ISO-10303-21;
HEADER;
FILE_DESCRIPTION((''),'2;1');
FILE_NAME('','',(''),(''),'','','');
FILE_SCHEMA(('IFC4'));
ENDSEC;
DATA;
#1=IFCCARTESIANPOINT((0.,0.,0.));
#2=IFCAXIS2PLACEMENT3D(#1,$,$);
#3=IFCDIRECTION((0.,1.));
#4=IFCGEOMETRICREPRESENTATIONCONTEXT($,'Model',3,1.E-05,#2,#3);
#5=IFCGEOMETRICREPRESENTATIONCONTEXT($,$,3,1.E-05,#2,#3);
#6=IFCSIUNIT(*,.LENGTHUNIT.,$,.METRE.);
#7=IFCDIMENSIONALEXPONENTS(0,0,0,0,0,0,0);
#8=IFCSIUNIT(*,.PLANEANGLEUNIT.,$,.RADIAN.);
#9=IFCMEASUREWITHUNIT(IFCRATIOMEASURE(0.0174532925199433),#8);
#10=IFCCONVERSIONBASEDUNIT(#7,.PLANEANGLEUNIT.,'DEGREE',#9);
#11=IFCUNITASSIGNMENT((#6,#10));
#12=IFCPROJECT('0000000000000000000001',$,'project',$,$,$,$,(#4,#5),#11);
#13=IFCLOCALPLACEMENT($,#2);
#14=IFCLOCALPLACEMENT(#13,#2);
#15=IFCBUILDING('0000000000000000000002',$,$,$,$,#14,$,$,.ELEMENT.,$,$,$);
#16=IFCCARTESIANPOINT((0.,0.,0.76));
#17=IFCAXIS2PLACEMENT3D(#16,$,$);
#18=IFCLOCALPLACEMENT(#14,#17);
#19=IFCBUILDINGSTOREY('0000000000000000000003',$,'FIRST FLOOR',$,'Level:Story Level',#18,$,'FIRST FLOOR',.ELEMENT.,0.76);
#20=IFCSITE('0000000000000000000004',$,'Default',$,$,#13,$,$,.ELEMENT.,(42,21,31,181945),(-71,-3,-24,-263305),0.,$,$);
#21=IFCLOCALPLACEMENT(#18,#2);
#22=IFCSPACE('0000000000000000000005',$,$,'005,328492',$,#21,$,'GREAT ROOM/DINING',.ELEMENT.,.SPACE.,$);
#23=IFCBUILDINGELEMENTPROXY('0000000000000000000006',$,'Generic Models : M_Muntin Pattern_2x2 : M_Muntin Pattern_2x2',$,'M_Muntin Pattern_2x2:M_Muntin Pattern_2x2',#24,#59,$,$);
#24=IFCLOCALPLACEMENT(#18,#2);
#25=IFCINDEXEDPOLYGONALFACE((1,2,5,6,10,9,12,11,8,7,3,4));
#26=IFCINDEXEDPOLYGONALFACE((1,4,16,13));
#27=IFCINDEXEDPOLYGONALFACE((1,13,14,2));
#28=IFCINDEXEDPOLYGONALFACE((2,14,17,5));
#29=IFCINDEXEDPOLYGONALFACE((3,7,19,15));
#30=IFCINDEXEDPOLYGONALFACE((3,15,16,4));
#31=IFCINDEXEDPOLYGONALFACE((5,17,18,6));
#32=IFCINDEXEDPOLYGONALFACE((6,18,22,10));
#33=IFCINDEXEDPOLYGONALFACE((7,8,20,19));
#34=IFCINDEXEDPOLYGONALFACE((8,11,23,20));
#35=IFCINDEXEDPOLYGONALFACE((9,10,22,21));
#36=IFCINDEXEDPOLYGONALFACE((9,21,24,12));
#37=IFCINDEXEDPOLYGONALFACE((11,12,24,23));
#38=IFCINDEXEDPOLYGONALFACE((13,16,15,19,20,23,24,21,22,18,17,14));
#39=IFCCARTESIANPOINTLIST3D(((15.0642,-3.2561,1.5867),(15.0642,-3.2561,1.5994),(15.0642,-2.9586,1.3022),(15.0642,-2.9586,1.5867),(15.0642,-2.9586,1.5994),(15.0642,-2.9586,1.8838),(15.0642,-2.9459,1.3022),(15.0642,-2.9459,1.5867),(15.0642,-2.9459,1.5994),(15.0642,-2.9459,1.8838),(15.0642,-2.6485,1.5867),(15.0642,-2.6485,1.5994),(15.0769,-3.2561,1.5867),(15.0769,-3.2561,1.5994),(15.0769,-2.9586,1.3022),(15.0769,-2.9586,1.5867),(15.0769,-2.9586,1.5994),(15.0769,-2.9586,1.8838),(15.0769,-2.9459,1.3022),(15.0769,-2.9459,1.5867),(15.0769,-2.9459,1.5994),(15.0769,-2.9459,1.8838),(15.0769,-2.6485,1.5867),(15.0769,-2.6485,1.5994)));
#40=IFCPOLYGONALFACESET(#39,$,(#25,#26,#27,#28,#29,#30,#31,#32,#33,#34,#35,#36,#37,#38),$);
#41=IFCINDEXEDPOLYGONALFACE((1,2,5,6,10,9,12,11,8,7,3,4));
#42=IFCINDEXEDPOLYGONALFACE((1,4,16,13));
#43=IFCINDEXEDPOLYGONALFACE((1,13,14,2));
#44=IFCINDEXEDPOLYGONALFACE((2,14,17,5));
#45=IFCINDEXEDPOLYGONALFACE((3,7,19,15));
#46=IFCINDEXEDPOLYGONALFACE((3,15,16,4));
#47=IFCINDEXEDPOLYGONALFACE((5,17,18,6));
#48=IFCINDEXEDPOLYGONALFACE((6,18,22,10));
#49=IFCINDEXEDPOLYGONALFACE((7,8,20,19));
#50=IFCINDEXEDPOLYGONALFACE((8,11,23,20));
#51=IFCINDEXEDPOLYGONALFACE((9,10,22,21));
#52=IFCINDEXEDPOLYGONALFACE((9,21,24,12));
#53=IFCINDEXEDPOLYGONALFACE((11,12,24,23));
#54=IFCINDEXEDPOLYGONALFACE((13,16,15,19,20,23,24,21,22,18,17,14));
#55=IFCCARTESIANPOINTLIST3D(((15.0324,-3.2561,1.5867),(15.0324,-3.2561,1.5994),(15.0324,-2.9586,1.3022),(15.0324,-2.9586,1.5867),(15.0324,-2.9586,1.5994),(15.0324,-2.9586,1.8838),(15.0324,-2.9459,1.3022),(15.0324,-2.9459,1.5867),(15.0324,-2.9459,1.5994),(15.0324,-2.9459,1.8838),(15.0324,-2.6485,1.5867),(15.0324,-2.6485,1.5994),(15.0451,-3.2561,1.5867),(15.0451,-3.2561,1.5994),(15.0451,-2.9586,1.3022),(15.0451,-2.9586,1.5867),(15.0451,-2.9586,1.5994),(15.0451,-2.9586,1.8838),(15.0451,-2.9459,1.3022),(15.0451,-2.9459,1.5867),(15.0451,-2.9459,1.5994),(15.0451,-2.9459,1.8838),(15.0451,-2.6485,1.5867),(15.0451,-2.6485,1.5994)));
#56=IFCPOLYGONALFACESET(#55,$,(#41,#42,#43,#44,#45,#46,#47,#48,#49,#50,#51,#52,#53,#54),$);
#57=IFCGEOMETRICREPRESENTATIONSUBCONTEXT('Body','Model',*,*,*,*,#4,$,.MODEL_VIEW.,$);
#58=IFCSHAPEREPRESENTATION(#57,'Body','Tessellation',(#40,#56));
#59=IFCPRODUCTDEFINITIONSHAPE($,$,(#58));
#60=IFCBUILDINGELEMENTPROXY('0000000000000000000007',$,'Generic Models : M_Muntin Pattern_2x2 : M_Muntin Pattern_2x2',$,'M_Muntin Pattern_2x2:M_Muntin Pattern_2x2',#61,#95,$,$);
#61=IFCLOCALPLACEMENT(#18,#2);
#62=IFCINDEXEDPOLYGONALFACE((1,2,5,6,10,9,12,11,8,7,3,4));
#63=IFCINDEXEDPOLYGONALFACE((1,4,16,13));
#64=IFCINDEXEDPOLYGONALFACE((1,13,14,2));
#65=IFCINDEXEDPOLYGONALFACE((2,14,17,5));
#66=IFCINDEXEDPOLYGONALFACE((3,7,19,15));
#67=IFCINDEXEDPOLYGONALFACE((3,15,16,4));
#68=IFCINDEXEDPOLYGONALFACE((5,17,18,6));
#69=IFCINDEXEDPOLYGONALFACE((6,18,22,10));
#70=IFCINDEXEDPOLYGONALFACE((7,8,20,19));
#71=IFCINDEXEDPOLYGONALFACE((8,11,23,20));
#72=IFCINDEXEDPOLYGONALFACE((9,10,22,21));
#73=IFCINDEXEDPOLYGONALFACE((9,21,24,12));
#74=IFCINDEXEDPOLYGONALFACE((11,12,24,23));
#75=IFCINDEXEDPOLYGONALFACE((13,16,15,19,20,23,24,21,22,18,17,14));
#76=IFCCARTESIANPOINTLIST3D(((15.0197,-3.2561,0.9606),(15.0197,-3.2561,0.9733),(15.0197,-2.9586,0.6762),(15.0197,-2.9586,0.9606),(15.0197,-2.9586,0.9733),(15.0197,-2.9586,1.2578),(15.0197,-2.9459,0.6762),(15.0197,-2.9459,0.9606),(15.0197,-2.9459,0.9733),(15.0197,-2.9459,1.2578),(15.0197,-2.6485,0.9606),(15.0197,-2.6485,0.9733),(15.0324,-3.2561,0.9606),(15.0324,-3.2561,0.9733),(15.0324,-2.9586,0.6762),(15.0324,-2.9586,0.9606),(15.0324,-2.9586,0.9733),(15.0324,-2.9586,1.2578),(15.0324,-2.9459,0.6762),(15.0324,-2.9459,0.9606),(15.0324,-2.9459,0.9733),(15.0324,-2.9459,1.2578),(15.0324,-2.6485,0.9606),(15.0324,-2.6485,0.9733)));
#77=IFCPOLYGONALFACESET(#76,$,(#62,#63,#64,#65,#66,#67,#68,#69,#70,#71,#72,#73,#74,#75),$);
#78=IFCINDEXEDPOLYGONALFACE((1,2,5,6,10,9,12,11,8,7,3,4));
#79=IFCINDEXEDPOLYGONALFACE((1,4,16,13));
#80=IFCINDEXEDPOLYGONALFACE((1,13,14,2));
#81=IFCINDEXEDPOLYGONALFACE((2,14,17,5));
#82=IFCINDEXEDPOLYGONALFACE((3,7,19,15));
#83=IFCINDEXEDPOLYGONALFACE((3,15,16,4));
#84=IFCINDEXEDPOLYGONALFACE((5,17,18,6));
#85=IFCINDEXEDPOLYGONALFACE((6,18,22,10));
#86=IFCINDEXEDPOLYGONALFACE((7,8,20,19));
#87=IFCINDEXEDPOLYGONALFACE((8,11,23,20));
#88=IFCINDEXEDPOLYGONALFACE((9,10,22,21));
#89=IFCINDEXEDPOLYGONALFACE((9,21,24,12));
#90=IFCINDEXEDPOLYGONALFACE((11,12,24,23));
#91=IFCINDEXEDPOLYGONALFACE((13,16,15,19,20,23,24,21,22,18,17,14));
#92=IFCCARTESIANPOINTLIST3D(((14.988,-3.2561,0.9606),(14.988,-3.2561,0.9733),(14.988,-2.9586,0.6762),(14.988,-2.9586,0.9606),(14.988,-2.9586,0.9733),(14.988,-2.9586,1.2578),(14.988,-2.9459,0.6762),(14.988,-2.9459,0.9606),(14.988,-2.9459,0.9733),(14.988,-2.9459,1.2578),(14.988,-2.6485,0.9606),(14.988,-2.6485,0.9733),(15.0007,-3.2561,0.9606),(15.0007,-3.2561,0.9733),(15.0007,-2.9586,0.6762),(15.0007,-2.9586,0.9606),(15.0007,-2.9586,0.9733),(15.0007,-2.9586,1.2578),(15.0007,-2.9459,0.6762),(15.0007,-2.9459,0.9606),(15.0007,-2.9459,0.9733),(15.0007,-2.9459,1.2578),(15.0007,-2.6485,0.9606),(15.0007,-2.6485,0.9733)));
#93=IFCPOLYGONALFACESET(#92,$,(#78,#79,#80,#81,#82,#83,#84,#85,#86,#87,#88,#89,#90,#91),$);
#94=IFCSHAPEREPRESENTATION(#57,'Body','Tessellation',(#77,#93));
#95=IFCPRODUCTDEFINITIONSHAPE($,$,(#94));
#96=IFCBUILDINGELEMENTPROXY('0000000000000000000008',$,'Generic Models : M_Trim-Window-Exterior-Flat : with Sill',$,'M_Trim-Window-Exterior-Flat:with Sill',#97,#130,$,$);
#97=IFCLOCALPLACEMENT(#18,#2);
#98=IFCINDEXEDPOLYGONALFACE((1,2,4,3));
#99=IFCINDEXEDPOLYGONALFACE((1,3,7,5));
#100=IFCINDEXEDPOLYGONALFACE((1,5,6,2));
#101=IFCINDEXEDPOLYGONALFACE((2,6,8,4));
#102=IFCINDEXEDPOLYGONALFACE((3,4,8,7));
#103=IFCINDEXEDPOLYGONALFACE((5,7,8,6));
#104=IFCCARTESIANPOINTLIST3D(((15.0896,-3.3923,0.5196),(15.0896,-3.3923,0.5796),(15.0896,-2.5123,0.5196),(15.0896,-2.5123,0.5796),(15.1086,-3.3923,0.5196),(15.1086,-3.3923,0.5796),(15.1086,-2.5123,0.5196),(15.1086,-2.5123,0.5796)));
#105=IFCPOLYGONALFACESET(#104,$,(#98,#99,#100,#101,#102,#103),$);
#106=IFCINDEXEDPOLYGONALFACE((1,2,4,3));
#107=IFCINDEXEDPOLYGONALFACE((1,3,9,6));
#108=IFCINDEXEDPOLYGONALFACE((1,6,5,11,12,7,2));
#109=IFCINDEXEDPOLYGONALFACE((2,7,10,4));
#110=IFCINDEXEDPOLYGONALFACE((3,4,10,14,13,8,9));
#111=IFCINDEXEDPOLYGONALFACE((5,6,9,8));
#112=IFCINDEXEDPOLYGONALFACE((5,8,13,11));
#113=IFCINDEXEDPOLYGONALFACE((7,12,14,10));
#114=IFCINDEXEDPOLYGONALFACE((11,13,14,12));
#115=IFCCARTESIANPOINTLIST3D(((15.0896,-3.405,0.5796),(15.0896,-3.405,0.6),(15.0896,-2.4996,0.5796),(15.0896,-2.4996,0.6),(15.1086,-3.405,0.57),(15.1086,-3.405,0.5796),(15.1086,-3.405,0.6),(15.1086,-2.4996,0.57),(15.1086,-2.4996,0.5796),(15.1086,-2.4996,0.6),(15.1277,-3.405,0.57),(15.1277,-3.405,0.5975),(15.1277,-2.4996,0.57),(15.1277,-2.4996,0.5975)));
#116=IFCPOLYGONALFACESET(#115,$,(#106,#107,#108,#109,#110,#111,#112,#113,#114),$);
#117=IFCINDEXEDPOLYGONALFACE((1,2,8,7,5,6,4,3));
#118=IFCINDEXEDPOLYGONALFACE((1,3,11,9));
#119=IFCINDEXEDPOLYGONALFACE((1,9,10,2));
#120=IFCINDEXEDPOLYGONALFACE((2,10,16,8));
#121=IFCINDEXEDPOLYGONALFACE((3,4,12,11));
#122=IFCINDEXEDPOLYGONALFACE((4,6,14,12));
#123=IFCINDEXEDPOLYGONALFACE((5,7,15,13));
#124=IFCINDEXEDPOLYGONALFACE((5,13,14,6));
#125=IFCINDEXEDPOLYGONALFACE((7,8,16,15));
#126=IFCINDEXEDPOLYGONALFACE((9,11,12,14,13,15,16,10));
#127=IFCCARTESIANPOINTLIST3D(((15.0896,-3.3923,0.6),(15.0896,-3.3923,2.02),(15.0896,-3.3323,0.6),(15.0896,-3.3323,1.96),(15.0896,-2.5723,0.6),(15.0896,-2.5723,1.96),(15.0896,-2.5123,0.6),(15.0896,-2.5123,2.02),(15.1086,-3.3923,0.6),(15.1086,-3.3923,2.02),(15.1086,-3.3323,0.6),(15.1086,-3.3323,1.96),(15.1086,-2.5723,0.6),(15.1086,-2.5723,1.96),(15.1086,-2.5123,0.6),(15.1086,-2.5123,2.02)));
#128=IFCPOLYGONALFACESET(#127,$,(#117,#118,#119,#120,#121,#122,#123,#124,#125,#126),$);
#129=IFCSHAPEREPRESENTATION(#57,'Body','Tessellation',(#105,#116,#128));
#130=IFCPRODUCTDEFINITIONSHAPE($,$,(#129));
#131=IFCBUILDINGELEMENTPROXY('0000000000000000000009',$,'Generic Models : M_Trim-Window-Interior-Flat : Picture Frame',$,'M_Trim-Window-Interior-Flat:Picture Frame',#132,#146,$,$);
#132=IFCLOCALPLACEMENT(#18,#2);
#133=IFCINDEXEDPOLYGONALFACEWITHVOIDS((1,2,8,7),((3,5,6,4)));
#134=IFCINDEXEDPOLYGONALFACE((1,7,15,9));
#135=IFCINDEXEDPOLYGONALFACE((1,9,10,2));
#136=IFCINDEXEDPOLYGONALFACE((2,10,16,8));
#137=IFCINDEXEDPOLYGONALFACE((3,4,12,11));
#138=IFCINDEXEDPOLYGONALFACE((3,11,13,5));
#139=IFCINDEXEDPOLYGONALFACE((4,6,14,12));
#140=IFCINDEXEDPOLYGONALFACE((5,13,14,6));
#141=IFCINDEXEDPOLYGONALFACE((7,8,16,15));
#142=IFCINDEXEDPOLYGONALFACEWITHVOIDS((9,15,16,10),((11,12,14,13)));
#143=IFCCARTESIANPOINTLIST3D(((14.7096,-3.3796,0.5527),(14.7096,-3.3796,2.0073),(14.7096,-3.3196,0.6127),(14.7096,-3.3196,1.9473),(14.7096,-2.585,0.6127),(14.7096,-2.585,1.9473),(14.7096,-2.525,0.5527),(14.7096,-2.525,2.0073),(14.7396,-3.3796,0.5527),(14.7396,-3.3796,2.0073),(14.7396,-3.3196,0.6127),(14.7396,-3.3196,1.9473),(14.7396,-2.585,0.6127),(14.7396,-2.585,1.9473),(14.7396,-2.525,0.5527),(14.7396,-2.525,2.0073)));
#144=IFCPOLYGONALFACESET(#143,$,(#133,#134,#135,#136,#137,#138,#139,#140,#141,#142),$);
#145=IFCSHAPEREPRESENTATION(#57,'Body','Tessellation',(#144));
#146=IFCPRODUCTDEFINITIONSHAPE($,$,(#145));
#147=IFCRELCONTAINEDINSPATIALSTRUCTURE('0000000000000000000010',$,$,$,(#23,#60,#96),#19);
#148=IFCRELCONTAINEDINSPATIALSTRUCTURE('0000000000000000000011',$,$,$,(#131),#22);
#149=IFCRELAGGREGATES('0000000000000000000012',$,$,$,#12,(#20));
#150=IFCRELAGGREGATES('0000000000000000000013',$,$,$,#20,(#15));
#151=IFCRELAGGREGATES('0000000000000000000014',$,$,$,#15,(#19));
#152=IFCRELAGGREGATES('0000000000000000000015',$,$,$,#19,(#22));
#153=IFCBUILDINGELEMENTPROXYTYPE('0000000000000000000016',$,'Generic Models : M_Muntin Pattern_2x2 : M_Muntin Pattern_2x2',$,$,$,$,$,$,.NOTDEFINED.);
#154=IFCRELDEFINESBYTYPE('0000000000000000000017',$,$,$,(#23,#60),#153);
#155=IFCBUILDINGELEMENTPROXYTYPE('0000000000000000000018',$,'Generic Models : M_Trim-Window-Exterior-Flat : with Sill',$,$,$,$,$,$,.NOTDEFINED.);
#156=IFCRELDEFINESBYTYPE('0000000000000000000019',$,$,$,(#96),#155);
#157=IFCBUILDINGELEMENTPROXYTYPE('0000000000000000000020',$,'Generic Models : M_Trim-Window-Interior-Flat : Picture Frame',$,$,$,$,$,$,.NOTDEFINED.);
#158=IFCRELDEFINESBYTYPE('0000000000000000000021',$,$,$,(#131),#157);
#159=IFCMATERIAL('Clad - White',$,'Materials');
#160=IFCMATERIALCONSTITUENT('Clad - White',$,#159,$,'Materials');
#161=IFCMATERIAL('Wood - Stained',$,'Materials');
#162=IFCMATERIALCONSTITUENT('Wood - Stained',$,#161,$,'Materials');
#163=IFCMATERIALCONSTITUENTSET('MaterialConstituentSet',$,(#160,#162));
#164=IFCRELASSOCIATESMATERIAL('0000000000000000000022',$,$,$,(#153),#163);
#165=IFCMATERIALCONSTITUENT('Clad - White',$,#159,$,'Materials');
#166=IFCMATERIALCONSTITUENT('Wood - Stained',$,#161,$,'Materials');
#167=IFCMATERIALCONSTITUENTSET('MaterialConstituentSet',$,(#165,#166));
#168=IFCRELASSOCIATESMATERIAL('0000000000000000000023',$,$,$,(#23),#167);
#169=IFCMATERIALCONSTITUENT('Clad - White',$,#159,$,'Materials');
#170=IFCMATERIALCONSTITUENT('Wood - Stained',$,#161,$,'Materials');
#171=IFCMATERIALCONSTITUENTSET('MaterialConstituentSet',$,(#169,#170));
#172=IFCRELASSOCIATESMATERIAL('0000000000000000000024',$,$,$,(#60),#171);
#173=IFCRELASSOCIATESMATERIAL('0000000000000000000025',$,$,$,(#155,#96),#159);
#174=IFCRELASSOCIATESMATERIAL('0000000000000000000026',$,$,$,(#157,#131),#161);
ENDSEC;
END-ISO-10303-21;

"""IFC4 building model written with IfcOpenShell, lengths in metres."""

from ifc_helpers import new_model, entity, si_unit, converted_unit, direction, frame, frame_2d, origin, place, context, subcontext, project, spatial, polyline, rectangle, outline, extrude, source, transform, mapped, material, constituent, constituent_set, type_object, type_shapes, element, save


model = new_model("IFC4")

# Units and contexts
model_context = context("Model", 3, precision=1e-05, world=origin(), true_north=direction((0.0, 1.0)))
context_of_model = context(None, 3, precision=1e-05, world=origin(), true_north=direction((0.0, 1.0)))
body_context = subcontext(model_context, "Body", "Model", "MODEL_VIEW")
ifc_project = project(units=[si_unit("LENGTHUNIT", "METRE"), converted_unit("PLANEANGLEUNIT", "DEGREE", entity("IfcRatioMeasure", 0.0174532925199433), si_unit("PLANEANGLEUNIT", "RADIAN"), dimensions=[0, 0, 0, 0, 0, 0, 0])], contexts=[model_context, context_of_model])

# Site, building, storey
site_placement = place(None, origin())
site = spatial("IfcSite", under=ifc_project, at=site_placement, Name="Default", CompositionType="ELEMENT", RefLatitude=(42, 21, 31, 181945), RefLongitude=(-71, -3, -24, -263305), RefElevation=0.0)
building_placement = place(site_placement, origin())
building = spatial("IfcBuilding", under=site, at=building_placement, CompositionType="ELEMENT")
storey_placement = place(building_placement, frame((0.0, 0.0, 0.76)))
storey = spatial("IfcBuildingStorey", under=building, at=storey_placement, Name="FIRST FLOOR", ObjectType="Level:Story Level", LongName="FIRST FLOOR", CompositionType="ELEMENT", Elevation=0.76)

# Shared definitions
ifc_material_1 = material(Name="Wood - Stained", Category="Materials")

# Shared definitions
ifc_material_2 = material(Name="Clad - White", Category="Materials")

# Building element proxies
ifc_constituent_1 = constituent(ifc_material_2, Name="Clad - White", Category="Materials")
ifc_constituent_2 = constituent(ifc_material_1, Name="Wood - Stained", Category="Materials")
ifc_constituent_set_1 = constituent_set(constituents=[ifc_constituent_1, ifc_constituent_2], Name="MaterialConstituentSet")
ifc_constituent_3 = constituent(ifc_material_2, Name="Clad - White", Category="Materials")
ifc_constituent_4 = constituent(ifc_material_1, Name="Wood - Stained", Category="Materials")
ifc_constituent_set_2 = constituent_set(constituents=[ifc_constituent_3, ifc_constituent_4], Name="MaterialConstituentSet")
building_element_proxy_type_1 = type_object("IfcBuildingElementProxyType", Name="Generic Models : M_Muntin Pattern_2x2 : M_Muntin Pattern_2x2", PredefinedType="NOTDEFINED", material=ifc_constituent_set_2)
shared_shape_1 = source(origin(), body_context, "Body", "SweptSolid", [
    extrude(outline(polyline([(0.0064, -0.0064), (0.2908, -0.0064), (0.2908, 0.0063), (0.0064, 0.0063), (0.0064, 0.3038), (-0.0063, 0.3038), (-0.0063, 0.0063), (-0.2908, 0.0063), (-0.2908, -0.0064), (-0.0063, -0.0064), (-0.0063, -0.3038), (0.0064, -0.3038), (0.0064, -0.0064)])), frame((0.0, 0.0095, 0.2908), z_axis=(0.0, 1.0, 0.0), x_axis=(0.0, 0.0, 1.0)), (0.0, 0.0, 1.0), 0.0127),
    extrude(outline(polyline([(0.0064, -0.0064), (0.2908, -0.0064), (0.2908, 0.0063), (0.0064, 0.0063), (0.0064, 0.3038), (-0.0063, 0.3038), (-0.0063, 0.0063), (-0.2908, 0.0063), (-0.2908, -0.0064), (-0.0063, -0.0064), (-0.0063, -0.3038), (0.0064, -0.3038), (0.0064, -0.0064)])), frame((0.0, -0.0222, 0.2908), z_axis=(0.0, 1.0, 0.0), x_axis=(0.0, 0.0, 1.0)), (0.0, 0.0, 1.0), 0.0127),
])
type_shapes(building_element_proxy_type_1, [shared_shape_1])
proxy_1_placement = place(storey_placement, frame((15.0546, -2.9523, 1.3022), z_axis=(0.0, 0.0, 1.0), x_axis=(0.0, -1.0, 0.0)))
element("IfcBuildingElementProxy", 1, at=proxy_1_placement, inside=storey, type_object=building_element_proxy_type_1, material=ifc_constituent_set_1, Name="Generic Models : M_Muntin Pattern_2x2 : M_Muntin Pattern_2x2", ObjectType="M_Muntin Pattern_2x2:M_Muntin Pattern_2x2", context=body_context, shape_type="MappedRepresentation", body=[
    mapped(shared_shape_1, transform((0.0, 0.0, 0.0), scale=1.0)),
])
ifc_constituent_5 = constituent(ifc_material_2, Name="Clad - White", Category="Materials")
ifc_constituent_6 = constituent(ifc_material_1, Name="Wood - Stained", Category="Materials")
ifc_constituent_set_3 = constituent_set(constituents=[ifc_constituent_5, ifc_constituent_6], Name="MaterialConstituentSet")
proxy_2_placement = place(storey_placement, frame((15.0102, -2.9523, 0.6762), z_axis=(0.0, 0.0, 1.0), x_axis=(0.0, -1.0, 0.0)))
element("IfcBuildingElementProxy", 2, at=proxy_2_placement, inside=storey, type_object=building_element_proxy_type_1, material=ifc_constituent_set_3, Name="Generic Models : M_Muntin Pattern_2x2 : M_Muntin Pattern_2x2", ObjectType="M_Muntin Pattern_2x2:M_Muntin Pattern_2x2", context=body_context, shape_type="MappedRepresentation", body=[
    mapped(shared_shape_1, transform((0.0, 0.0, 0.0), scale=1.0)),
])
building_element_proxy_type_2 = type_object("IfcBuildingElementProxyType", Name="Generic Models : M_Trim-Window-Exterior-Flat : with Sill", PredefinedType="NOTDEFINED", material=ifc_material_2)
shared_shape_2 = source(origin(), body_context, "Body", "SweptSolid", [
    extrude(rectangle(XDim=0.88, YDim=0.06, at=frame_2d((0.0, 0.0), x_axis=(1.0, 0.0))), frame((0.0, -1.4104, 0.0), z_axis=(0.0, 0.0, 1.0), x_axis=(-1.0, 0.0, 0.0)), (0.0, 0.0, 1.0), 0.0191),
    extrude(outline(polyline([(-0.019, -0.0152), (0.0, -0.0152), (0.0, -0.0057), (0.019, -0.0057), (0.019, 0.0148), (0.0, 0.0148), (-0.019, 0.0123), (-0.019, -0.0152)])), frame((-0.4527, -1.3748, 0.019), z_axis=(1.0, 0.0, 0.0), x_axis=(0.0, 0.0, -1.0)), (0.0, 0.0, 1.0), 0.9054),
    extrude(outline(polyline([(-0.725, -0.44), (0.695, -0.44), (0.695, -0.38), (-0.665, -0.38), (-0.665, 0.38), (0.695, 0.38), (0.695, 0.44), (-0.725, 0.44), (-0.725, -0.44)])), frame((0.0, -0.665, 0.0), z_axis=(0.0, 0.0, 1.0), x_axis=(0.0, -1.0, 0.0)), (0.0, 0.0, 1.0), 0.0191),
])
type_shapes(building_element_proxy_type_2, [shared_shape_2])
proxy_3_placement = place(storey_placement, frame((15.0896, -2.9523, 1.96), z_axis=(1.0, 0.0, 0.0), x_axis=(0.0, 1.0, 0.0)))
element("IfcBuildingElementProxy", 3, at=proxy_3_placement, inside=storey, type_object=building_element_proxy_type_2, material=ifc_material_2, Name="Generic Models : M_Trim-Window-Exterior-Flat : with Sill", ObjectType="M_Trim-Window-Exterior-Flat:with Sill", context=body_context, shape_type="MappedRepresentation", body=[
    mapped(shared_shape_2, transform((0.0, 0.0, 0.0), scale=1.0)),
])

# Shared definitions
space_1_placement = place(storey_placement, origin())
space_1 = spatial("IfcSpace", under=storey, at=space_1_placement, Description="005,328492", LongName="GREAT ROOM/DINING", CompositionType="ELEMENT", PredefinedType="SPACE")

# Building element proxy
building_element_proxy_type_3 = type_object("IfcBuildingElementProxyType", Name="Generic Models : M_Trim-Window-Interior-Flat : Picture Frame", PredefinedType="NOTDEFINED", material=ifc_material_1)
shared_shape_3 = source(origin(), body_context, "Body", "SweptSolid", [
    extrude(outline(polyline([(-0.4273, -0.7273), (0.4273, -0.7273), (0.4273, 0.7273), (-0.4273, 0.7273), (-0.4273, -0.7273)]), holes=[polyline([(-0.3673, -0.6673), (-0.3673, 0.6673), (0.3673, 0.6673), (0.3673, -0.6673), (-0.3673, -0.6673)])]), frame((0.0, -0.68, 0.0), z_axis=(0.0, 0.0, 1.0), x_axis=(-1.0, 0.0, 0.0)), (0.0, 0.0, 1.0), 0.03),
])
type_shapes(building_element_proxy_type_3, [shared_shape_3])
proxy_4_placement = place(space_1_placement, frame((14.7396, -2.9523, 1.96), z_axis=(-1.0, 0.0, 0.0), x_axis=(0.0, -1.0, 0.0)))
element("IfcBuildingElementProxy", 4, at=proxy_4_placement, inside=space_1, type_object=building_element_proxy_type_3, material=ifc_material_1, Name="Generic Models : M_Trim-Window-Interior-Flat : Picture Frame", ObjectType="M_Trim-Window-Interior-Flat:Picture Frame", context=body_context, shape_type="MappedRepresentation", body=[
    mapped(shared_shape_3, transform((0.0, 0.0, 0.0), scale=1.0)),
])

save(model, "model.ifc")
